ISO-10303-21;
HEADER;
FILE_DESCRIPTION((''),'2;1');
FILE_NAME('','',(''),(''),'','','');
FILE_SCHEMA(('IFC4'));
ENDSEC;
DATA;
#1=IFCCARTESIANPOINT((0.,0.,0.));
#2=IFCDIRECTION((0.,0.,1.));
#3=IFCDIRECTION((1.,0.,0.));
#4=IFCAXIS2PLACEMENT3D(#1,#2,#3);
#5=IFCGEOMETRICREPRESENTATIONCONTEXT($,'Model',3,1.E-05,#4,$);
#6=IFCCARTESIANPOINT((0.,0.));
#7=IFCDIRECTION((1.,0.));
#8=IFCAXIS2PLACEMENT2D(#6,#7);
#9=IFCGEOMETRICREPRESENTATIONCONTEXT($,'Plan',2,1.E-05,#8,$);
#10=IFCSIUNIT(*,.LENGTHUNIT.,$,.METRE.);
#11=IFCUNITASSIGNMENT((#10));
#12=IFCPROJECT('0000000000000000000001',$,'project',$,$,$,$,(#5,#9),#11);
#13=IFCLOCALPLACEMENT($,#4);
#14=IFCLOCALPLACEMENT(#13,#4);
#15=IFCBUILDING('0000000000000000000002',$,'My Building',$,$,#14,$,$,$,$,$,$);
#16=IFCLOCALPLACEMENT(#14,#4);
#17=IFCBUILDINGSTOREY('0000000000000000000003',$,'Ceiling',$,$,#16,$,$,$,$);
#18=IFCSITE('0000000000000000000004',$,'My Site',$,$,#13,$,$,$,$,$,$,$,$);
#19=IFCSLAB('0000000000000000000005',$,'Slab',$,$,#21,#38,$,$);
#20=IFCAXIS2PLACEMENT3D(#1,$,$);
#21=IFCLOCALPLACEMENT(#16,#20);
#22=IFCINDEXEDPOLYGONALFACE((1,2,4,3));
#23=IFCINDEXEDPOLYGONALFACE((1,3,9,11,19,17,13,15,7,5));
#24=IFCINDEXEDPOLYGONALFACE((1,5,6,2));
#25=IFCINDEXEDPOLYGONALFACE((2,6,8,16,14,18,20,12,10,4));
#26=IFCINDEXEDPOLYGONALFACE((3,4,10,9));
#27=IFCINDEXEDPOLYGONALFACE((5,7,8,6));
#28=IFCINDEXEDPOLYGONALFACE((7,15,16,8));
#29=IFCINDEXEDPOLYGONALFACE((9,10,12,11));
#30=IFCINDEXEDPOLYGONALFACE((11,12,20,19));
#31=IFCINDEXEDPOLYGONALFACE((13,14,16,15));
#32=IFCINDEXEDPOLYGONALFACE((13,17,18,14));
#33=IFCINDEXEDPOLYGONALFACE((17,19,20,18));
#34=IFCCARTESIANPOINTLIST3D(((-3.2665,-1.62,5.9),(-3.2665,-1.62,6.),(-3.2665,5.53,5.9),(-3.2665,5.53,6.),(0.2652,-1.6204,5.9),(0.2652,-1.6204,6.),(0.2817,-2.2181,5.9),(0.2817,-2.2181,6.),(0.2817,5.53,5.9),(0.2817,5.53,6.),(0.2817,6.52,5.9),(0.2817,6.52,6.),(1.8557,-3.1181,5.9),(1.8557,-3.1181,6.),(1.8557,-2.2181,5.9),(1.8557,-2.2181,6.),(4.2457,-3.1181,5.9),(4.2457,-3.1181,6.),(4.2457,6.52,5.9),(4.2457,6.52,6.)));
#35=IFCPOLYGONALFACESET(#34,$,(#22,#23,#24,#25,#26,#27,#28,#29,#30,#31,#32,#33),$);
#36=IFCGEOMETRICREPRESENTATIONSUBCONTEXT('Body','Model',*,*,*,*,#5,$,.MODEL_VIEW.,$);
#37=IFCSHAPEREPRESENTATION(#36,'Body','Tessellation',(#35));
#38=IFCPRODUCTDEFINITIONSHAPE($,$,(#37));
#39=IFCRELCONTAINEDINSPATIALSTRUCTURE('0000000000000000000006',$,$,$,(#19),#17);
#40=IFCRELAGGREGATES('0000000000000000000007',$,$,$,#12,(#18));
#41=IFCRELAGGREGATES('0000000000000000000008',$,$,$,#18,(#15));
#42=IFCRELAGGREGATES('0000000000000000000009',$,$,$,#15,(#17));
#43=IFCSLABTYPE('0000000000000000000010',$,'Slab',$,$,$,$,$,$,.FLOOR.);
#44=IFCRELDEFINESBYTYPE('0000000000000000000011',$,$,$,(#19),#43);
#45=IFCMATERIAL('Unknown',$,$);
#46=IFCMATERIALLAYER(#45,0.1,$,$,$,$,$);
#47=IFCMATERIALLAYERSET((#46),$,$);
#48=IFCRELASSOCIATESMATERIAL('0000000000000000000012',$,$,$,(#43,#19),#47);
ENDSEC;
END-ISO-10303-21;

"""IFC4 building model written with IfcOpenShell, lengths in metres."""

from ifc_helpers import new_model, si_unit, frame, origin_with_axes, origin_2d_with_axis, place, context, subcontext, project, spatial, indexed_curve, outline, extrude, material, layer, layer_set, layer_usage, type_object, element, save


model = new_model("IFC4")

# Units and contexts
model_context = context("Model", 3, precision=1e-05, world=origin_with_axes())
plan_context = context("Plan", 2, precision=1e-05, world=origin_2d_with_axis())
body_context = subcontext(model_context, "Body", "Model", "MODEL_VIEW")
ifc_project = project(units=[si_unit("LENGTHUNIT", "METRE")], contexts=[model_context, plan_context])

# Site, building, storey
site_placement = place(None, origin_with_axes())
site = spatial("IfcSite", under=ifc_project, at=site_placement, Name="My Site")
building_placement = place(site_placement, origin_with_axes())
building = spatial("IfcBuilding", under=site, at=building_placement, Name="My Building")
storey_placement = place(building_placement, origin_with_axes())
storey = spatial("IfcBuildingStorey", under=building, at=storey_placement, Name="Ceiling")

# Slab
ifc_material = material(Name="Unknown")
ifc_layer = layer(ifc_material, 0.1)
ifc_layer_set = layer_set([ifc_layer])
ifc_layer_usage = layer_usage(ifc_layer_set, "AXIS3", "POSITIVE", -0.1)
slab_type = type_object("IfcSlabType", Name="Slab", PredefinedType="FLOOR", material=ifc_layer_set)
slab_placement = place(storey_placement, frame((4.2457, 6.52, 6.0), z_axis=(0.0, 0.0, 1.0), x_axis=(1.0, 0.0, 0.0)))
element("IfcSlab", 1, at=slab_placement, inside=storey, type_object=slab_type, material=ifc_layer_usage, Name="Slab", context=body_context, shape_type="SweptSolid", body=[
    extrude(outline(indexed_curve([(0.0, 0.0), (-3.964, 0.0), (-3.964, -0.99), (-7.5122, -0.99), (-7.5122, -8.14), (-3.9805, -8.1404), (-3.964, -8.7381), (-2.39, -8.7381), (-2.39, -9.6381), (0.0, -9.6381), (0.0, 0.0)])), frame((0.0, 0.0, -0.1), z_axis=(0.0, 0.0, 1.0), x_axis=(1.0, 0.0, 0.0)), (0.0, 0.0, 1.0), 0.1),
])

save(model, "model.ifc")
